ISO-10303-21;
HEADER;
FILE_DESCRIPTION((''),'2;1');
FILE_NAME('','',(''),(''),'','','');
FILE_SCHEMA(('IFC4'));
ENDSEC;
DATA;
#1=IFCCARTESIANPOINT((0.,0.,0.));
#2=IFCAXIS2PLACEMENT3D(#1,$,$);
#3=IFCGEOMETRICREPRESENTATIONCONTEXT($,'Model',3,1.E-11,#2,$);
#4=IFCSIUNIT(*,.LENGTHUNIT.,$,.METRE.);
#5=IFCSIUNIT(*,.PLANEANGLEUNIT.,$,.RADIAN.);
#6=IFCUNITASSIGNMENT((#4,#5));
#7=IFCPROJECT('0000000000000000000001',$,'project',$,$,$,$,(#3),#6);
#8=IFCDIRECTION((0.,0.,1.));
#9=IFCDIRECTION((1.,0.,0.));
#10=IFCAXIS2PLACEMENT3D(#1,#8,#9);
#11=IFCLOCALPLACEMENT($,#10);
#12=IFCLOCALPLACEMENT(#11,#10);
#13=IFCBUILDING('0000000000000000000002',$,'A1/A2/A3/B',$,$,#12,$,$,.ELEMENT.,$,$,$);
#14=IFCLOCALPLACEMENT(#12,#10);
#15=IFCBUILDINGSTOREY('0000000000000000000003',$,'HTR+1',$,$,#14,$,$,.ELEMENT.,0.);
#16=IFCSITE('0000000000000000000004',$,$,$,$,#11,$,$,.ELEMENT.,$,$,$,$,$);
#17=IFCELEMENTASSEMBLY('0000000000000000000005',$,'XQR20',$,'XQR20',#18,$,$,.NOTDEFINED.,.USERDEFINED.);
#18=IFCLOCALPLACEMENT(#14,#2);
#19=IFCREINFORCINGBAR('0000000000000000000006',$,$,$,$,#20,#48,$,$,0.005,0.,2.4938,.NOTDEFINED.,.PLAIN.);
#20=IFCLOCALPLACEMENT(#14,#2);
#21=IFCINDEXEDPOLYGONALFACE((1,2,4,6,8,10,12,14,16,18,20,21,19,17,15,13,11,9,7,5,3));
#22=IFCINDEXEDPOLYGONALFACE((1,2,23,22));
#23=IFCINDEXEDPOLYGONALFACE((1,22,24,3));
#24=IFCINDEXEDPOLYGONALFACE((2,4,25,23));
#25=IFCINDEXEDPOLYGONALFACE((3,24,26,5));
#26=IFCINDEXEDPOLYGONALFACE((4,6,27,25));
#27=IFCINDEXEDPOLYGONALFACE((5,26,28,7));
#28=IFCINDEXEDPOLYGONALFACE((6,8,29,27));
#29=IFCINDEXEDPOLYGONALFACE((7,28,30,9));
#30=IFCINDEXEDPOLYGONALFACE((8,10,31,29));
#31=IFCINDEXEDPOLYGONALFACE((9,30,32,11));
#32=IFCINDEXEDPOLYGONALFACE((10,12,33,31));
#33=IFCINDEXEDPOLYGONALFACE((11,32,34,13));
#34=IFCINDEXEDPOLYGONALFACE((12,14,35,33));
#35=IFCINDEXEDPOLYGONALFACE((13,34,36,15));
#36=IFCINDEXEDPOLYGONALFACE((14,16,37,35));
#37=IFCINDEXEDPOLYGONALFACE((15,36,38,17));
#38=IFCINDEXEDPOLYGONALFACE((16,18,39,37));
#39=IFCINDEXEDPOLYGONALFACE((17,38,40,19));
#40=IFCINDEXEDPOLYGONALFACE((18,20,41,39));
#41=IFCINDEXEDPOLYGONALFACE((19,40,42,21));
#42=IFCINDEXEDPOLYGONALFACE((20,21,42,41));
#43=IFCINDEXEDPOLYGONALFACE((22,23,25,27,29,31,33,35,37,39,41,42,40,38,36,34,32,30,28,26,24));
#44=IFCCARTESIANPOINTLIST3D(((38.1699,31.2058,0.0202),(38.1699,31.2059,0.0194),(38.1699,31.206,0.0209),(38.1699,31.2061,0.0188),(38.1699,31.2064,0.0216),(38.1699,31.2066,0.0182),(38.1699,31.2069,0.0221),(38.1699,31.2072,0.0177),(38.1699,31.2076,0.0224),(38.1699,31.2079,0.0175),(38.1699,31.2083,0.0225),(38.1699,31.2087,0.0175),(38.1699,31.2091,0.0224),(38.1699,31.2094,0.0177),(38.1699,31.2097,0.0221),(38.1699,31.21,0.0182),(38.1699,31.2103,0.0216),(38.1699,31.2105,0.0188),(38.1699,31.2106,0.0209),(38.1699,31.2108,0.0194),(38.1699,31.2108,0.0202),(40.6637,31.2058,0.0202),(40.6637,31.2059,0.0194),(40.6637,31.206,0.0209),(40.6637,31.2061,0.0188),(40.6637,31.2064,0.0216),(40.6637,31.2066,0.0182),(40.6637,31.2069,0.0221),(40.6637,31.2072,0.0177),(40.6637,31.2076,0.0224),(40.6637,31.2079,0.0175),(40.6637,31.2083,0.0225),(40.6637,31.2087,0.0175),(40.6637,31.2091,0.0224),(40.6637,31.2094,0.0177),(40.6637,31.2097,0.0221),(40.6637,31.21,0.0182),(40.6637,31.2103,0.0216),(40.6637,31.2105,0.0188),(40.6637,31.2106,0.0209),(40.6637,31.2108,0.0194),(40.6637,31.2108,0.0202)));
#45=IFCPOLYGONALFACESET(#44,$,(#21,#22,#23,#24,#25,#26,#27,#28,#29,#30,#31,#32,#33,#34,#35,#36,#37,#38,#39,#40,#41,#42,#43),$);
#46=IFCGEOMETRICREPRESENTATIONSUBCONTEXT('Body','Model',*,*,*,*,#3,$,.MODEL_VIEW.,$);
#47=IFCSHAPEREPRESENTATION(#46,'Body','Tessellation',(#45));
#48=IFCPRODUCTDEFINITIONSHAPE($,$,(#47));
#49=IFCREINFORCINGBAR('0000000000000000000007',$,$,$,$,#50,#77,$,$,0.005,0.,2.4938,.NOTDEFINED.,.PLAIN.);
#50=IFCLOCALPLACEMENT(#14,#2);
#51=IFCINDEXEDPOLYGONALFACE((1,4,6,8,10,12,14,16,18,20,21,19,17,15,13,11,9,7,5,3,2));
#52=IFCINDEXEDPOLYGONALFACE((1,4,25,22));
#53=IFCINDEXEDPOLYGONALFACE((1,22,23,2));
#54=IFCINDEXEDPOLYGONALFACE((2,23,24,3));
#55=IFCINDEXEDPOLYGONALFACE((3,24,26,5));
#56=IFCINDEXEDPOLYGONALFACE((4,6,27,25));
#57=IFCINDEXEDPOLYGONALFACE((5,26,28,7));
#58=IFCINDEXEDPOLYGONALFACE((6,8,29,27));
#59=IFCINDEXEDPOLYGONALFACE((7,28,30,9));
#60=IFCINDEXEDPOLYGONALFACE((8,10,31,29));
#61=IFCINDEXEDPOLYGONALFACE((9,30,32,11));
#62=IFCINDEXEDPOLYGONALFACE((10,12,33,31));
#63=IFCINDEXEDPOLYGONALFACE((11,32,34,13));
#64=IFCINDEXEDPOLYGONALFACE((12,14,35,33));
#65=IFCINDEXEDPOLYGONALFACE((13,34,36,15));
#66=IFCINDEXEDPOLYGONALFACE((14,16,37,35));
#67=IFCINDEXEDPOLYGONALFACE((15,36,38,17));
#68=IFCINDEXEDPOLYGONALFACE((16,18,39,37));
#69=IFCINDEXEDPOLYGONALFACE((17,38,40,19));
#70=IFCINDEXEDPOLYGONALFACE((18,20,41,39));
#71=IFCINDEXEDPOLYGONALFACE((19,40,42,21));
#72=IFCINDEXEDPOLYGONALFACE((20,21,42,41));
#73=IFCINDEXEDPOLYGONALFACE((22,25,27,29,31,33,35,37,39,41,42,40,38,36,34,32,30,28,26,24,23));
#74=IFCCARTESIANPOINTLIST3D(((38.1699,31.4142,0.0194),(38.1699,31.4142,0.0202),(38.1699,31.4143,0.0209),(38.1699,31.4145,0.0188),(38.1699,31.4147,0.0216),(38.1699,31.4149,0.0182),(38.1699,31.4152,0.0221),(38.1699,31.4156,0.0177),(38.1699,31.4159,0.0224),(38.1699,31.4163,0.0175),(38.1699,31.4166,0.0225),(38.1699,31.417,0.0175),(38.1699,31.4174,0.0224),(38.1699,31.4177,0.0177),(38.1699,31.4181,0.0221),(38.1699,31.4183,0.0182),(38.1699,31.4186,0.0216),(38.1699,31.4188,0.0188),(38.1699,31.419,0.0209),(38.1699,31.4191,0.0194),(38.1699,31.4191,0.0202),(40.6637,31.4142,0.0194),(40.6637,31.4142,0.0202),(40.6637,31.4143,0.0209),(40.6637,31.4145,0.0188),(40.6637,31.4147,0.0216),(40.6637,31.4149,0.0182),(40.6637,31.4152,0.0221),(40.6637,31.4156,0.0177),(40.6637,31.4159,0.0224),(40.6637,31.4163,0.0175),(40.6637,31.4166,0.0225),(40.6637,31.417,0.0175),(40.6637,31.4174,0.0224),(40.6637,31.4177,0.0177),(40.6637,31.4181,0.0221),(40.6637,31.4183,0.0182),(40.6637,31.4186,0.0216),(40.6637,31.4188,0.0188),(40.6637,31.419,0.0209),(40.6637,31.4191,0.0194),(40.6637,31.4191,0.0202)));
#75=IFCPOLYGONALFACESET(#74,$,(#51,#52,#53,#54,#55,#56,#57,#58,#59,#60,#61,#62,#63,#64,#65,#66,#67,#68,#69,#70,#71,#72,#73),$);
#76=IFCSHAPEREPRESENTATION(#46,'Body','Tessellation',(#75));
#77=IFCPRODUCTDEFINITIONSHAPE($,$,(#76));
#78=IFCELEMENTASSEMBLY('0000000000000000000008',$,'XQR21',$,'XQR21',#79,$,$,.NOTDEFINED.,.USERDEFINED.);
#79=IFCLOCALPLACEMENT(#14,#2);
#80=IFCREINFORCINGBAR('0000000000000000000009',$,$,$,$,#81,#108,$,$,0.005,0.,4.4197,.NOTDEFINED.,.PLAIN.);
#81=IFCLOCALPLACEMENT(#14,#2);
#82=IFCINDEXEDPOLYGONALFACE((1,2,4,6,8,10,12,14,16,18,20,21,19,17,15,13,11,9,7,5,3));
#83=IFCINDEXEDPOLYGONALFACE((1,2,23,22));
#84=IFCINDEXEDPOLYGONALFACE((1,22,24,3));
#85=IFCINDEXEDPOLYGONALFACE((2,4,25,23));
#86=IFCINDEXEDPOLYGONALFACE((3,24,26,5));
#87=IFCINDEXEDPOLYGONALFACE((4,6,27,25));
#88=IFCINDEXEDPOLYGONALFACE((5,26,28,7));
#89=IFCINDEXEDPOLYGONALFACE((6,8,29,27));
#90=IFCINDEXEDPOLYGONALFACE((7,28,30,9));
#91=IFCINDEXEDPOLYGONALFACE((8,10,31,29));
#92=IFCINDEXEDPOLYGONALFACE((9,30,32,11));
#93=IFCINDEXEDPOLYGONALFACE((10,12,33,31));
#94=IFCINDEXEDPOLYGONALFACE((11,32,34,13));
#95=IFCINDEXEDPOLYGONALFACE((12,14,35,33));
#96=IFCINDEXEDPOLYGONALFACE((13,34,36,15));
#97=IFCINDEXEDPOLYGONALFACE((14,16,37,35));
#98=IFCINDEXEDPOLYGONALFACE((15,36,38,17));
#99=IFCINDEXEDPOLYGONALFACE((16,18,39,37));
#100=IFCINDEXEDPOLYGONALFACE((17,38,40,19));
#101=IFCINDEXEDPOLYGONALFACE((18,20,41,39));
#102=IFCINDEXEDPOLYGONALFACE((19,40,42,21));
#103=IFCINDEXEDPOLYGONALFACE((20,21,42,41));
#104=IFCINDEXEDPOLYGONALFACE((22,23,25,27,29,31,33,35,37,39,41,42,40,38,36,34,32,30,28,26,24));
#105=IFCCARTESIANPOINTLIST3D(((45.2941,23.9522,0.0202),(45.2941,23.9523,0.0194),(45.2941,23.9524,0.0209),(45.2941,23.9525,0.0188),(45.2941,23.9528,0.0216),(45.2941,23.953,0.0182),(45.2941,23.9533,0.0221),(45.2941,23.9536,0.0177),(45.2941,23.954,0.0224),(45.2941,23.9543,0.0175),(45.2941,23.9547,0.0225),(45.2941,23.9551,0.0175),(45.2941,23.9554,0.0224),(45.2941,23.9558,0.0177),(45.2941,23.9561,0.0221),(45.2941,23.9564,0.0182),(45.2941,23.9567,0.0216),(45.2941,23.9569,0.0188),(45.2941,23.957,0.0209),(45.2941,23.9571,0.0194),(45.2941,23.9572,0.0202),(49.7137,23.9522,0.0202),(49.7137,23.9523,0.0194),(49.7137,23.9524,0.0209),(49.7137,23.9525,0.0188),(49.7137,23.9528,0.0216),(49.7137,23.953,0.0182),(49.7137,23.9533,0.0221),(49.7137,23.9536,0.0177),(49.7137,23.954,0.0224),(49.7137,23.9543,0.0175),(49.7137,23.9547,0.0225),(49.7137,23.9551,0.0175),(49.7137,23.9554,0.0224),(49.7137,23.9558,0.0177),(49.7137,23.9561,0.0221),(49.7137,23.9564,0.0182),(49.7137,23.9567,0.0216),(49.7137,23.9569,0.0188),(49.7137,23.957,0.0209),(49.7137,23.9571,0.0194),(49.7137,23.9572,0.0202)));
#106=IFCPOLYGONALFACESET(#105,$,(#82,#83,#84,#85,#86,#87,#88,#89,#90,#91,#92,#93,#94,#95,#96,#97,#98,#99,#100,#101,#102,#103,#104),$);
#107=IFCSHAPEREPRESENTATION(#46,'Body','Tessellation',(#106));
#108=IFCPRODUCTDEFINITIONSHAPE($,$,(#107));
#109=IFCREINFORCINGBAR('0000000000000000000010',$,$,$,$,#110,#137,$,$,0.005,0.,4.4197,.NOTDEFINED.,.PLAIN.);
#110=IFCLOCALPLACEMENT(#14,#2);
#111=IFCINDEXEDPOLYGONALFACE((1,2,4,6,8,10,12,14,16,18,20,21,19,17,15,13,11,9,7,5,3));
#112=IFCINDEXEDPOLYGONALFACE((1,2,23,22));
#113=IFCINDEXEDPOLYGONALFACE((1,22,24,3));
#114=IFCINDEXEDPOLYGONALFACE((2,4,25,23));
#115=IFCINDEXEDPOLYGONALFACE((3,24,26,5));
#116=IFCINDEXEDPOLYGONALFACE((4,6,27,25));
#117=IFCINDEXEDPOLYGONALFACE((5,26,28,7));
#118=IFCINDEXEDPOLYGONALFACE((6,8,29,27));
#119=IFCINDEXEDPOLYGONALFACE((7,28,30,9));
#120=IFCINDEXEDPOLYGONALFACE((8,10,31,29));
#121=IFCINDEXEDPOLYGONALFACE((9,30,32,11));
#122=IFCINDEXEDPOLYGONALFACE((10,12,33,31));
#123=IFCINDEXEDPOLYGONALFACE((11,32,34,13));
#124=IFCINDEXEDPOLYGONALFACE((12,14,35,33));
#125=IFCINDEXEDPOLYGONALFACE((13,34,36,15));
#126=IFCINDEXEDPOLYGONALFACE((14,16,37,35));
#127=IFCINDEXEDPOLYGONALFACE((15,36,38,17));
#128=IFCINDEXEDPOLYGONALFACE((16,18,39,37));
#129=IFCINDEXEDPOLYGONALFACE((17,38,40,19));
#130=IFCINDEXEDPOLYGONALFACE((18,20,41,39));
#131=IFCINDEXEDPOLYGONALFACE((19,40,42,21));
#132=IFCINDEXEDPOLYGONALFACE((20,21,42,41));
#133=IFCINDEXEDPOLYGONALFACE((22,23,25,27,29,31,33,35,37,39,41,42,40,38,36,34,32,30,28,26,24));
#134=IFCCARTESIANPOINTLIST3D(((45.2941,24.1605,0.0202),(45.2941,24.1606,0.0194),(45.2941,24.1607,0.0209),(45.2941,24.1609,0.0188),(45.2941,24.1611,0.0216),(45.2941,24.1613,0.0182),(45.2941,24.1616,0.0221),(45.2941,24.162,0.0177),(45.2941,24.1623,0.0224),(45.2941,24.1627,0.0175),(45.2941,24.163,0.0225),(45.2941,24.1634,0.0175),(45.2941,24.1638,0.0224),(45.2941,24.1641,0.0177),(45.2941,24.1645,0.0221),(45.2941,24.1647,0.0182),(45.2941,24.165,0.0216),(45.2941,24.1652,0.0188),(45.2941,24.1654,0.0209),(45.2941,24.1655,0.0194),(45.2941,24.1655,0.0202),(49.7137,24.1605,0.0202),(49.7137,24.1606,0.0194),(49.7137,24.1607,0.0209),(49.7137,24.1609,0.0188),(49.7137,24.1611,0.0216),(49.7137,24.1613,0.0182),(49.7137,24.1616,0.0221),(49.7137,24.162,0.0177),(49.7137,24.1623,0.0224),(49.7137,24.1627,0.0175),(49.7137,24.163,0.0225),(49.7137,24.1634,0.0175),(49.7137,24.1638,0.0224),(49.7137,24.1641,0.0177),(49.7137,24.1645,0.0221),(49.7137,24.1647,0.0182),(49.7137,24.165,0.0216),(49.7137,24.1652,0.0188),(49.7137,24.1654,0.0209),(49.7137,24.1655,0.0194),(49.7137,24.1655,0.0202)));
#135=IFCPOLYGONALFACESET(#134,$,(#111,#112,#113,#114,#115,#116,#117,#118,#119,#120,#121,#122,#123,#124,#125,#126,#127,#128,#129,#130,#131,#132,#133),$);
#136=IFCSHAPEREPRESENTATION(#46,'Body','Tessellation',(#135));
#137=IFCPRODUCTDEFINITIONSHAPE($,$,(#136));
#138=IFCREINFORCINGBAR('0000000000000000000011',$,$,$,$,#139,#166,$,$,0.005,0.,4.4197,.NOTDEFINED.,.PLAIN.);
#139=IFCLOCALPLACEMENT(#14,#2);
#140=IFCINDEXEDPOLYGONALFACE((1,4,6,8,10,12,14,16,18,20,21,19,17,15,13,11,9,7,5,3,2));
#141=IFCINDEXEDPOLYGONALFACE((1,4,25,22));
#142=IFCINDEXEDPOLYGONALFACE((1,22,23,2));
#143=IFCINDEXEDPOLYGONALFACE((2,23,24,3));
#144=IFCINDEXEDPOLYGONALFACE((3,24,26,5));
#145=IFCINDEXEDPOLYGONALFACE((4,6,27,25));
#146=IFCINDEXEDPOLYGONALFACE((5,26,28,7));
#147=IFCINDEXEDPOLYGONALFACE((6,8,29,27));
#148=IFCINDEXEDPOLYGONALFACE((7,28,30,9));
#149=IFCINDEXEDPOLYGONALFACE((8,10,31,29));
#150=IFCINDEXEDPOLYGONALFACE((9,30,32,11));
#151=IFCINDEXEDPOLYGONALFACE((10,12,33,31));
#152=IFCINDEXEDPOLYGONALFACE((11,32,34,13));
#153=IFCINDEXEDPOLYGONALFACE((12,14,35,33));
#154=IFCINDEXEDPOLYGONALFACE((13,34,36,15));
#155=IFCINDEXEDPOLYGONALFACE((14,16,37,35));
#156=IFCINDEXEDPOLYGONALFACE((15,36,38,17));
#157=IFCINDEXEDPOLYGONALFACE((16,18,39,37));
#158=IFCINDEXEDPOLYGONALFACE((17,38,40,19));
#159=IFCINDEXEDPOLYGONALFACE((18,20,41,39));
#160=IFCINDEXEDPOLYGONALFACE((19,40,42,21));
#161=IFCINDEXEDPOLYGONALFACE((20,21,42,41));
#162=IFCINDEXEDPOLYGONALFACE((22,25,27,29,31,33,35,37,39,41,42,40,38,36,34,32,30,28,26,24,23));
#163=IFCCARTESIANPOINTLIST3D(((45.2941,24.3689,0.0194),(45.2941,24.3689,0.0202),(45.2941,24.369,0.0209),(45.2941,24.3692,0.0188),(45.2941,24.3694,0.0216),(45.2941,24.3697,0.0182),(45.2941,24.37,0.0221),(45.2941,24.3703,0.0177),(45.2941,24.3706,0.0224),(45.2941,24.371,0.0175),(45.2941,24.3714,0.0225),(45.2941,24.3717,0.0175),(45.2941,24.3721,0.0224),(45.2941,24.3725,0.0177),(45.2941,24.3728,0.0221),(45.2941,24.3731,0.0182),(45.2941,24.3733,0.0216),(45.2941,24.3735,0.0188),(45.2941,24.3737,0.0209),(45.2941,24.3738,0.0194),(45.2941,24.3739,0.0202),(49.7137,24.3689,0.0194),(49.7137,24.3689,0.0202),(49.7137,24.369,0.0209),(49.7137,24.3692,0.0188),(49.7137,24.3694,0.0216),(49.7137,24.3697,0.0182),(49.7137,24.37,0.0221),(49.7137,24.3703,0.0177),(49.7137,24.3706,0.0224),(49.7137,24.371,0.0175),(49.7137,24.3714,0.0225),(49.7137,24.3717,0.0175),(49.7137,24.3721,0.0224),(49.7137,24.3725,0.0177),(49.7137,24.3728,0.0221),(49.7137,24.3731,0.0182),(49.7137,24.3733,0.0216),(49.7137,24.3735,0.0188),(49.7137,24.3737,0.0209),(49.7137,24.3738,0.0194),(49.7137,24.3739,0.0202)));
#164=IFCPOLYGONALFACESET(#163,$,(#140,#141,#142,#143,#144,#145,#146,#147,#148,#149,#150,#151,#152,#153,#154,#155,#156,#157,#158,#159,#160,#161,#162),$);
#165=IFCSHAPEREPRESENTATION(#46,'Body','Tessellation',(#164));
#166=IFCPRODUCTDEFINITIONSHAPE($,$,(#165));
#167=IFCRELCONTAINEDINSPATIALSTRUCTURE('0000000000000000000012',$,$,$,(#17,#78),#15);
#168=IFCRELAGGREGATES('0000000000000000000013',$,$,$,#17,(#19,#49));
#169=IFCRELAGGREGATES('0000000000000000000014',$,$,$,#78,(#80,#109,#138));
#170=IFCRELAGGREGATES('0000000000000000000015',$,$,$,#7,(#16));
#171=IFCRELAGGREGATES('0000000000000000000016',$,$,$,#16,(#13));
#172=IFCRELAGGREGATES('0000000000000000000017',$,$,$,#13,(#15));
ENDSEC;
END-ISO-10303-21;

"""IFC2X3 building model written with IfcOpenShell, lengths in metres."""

from ifc_helpers import new_model, entity, si_unit, origin, origin_with_axes, place, context, subcontext, project, spatial, shape, element, aggregate, save


model = new_model("IFC2X3")

# Units and contexts
model_context = context("Model", 3, precision=1e-11, world=origin())
body_context = subcontext(model_context, "Body", "Model", "MODEL_VIEW")
ifc_project = project(units=[si_unit("LENGTHUNIT", "METRE"), si_unit("PLANEANGLEUNIT", "RADIAN")], contexts=[model_context])

# Site, building, storey
site_placement = place(None, origin_with_axes())
site = spatial("IfcSite", under=ifc_project, at=site_placement, CompositionType="ELEMENT")
building_placement = place(site_placement, origin_with_axes())
building = spatial("IfcBuilding", under=site, at=building_placement, Name="A1/A2/A3/B", CompositionType="ELEMENT")
storey_placement = place(building_placement, origin_with_axes())
storey = spatial("IfcBuildingStorey", under=building, at=storey_placement, Name="HTR+1", CompositionType="ELEMENT", Elevation=0.0)

# Element assemblies, reinforcing bars
assembly_1_placement = place(storey_placement, origin_with_axes())
assembly_1 = element("IfcElementAssembly", 1, at=assembly_1_placement, inside=storey, Name="XQR20", ObjectType="XQR20", AssemblyPlace="NOTDEFINED", PredefinedType="USERDEFINED")
reinforcing_bar_1_placement = place(assembly_1_placement, origin_with_axes())
reinforcing_bar_1 = element("IfcReinforcingBar", 2, at=reinforcing_bar_1_placement, BarLength=2.4938, BarRole="NOTDEFINED", BarSurface="PLAIN", CrossSectionArea=0.0, NominalDiameter=0.005, shapes=[
    shape(body_context, "Body", "AdvancedSweptSolid", [entity("IfcSweptDiskSolid", entity("IfcPolyline", [entity("IfcCartesianPoint", [38.1699, 31.2083, 0.02]), entity("IfcCartesianPoint", [40.6637, 31.2083, 0.02])]), 0.0025, None, 0.0, 2.4938)]),
    shape(body_context, "Body", "AdvancedSweptSolid", [entity("IfcSweptDiskSolid", entity("IfcPolyline", [entity("IfcCartesianPoint", [38.1699, 31.2083, 0.02]), entity("IfcCartesianPoint", [40.6637, 31.2083, 0.02])]), 0.0025, None, 0.0, 2.4938)]),
])
reinforcing_bar_2_placement = place(assembly_1_placement, origin_with_axes())
reinforcing_bar_2 = element("IfcReinforcingBar", 3, at=reinforcing_bar_2_placement, BarLength=2.4938, BarRole="NOTDEFINED", BarSurface="PLAIN", CrossSectionArea=0.0, NominalDiameter=0.005, shapes=[
    shape(body_context, "Body", "AdvancedSweptSolid", [entity("IfcSweptDiskSolid", entity("IfcPolyline", [entity("IfcCartesianPoint", [38.1699, 31.4166, 0.02]), entity("IfcCartesianPoint", [40.6637, 31.4166, 0.02])]), 0.0025, None, 0.0, 2.4938)]),
    shape(body_context, "Body", "AdvancedSweptSolid", [entity("IfcSweptDiskSolid", entity("IfcPolyline", [entity("IfcCartesianPoint", [38.1699, 31.4166, 0.02]), entity("IfcCartesianPoint", [40.6637, 31.4166, 0.02])]), 0.0025, None, 0.0, 2.4938)]),
])
aggregate(assembly_1, [reinforcing_bar_1, reinforcing_bar_2])
assembly_2_placement = place(storey_placement, origin_with_axes())
assembly_2 = element("IfcElementAssembly", 4, at=assembly_2_placement, inside=storey, Name="XQR21", ObjectType="XQR21", AssemblyPlace="NOTDEFINED", PredefinedType="USERDEFINED")
reinforcing_bar_3_placement = place(assembly_2_placement, origin_with_axes())
reinforcing_bar_3 = element("IfcReinforcingBar", 5, at=reinforcing_bar_3_placement, BarLength=4.4197, BarRole="NOTDEFINED", BarSurface="PLAIN", CrossSectionArea=0.0, NominalDiameter=0.005, shapes=[
    shape(body_context, "Body", "AdvancedSweptSolid", [entity("IfcSweptDiskSolid", entity("IfcPolyline", [entity("IfcCartesianPoint", [45.2941, 23.9547, 0.02]), entity("IfcCartesianPoint", [49.7137, 23.9547, 0.02])]), 0.0025, None, 0.0, 4.4197)]),
    shape(body_context, "Body", "AdvancedSweptSolid", [entity("IfcSweptDiskSolid", entity("IfcPolyline", [entity("IfcCartesianPoint", [45.2941, 23.9547, 0.02]), entity("IfcCartesianPoint", [49.7137, 23.9547, 0.02])]), 0.0025, None, 0.0, 4.4197)]),
])
reinforcing_bar_4_placement = place(assembly_2_placement, origin_with_axes())
reinforcing_bar_4 = element("IfcReinforcingBar", 6, at=reinforcing_bar_4_placement, BarLength=4.4197, BarRole="NOTDEFINED", BarSurface="PLAIN", CrossSectionArea=0.0, NominalDiameter=0.005, shapes=[
    shape(body_context, "Body", "AdvancedSweptSolid", [entity("IfcSweptDiskSolid", entity("IfcPolyline", [entity("IfcCartesianPoint", [45.2941, 24.163, 0.02]), entity("IfcCartesianPoint", [49.7137, 24.163, 0.02])]), 0.0025, None, 0.0, 4.4197)]),
    shape(body_context, "Body", "AdvancedSweptSolid", [entity("IfcSweptDiskSolid", entity("IfcPolyline", [entity("IfcCartesianPoint", [45.2941, 24.163, 0.02]), entity("IfcCartesianPoint", [49.7137, 24.163, 0.02])]), 0.0025, None, 0.0, 4.4197)]),
])
reinforcing_bar_5_placement = place(assembly_2_placement, origin_with_axes())
reinforcing_bar_5 = element("IfcReinforcingBar", 7, at=reinforcing_bar_5_placement, BarLength=4.4197, BarRole="NOTDEFINED", BarSurface="PLAIN", CrossSectionArea=0.0, NominalDiameter=0.005, shapes=[
    shape(body_context, "Body", "AdvancedSweptSolid", [entity("IfcSweptDiskSolid", entity("IfcPolyline", [entity("IfcCartesianPoint", [45.2941, 24.3714, 0.02]), entity("IfcCartesianPoint", [49.7137, 24.3714, 0.02])]), 0.0025, None, 0.0, 4.4197)]),
    shape(body_context, "Body", "AdvancedSweptSolid", [entity("IfcSweptDiskSolid", entity("IfcPolyline", [entity("IfcCartesianPoint", [45.2941, 24.3714, 0.02]), entity("IfcCartesianPoint", [49.7137, 24.3714, 0.02])]), 0.0025, None, 0.0, 4.4197)]),
])
aggregate(assembly_2, [reinforcing_bar_3, reinforcing_bar_4, reinforcing_bar_5])

save(model, "model.ifc")
